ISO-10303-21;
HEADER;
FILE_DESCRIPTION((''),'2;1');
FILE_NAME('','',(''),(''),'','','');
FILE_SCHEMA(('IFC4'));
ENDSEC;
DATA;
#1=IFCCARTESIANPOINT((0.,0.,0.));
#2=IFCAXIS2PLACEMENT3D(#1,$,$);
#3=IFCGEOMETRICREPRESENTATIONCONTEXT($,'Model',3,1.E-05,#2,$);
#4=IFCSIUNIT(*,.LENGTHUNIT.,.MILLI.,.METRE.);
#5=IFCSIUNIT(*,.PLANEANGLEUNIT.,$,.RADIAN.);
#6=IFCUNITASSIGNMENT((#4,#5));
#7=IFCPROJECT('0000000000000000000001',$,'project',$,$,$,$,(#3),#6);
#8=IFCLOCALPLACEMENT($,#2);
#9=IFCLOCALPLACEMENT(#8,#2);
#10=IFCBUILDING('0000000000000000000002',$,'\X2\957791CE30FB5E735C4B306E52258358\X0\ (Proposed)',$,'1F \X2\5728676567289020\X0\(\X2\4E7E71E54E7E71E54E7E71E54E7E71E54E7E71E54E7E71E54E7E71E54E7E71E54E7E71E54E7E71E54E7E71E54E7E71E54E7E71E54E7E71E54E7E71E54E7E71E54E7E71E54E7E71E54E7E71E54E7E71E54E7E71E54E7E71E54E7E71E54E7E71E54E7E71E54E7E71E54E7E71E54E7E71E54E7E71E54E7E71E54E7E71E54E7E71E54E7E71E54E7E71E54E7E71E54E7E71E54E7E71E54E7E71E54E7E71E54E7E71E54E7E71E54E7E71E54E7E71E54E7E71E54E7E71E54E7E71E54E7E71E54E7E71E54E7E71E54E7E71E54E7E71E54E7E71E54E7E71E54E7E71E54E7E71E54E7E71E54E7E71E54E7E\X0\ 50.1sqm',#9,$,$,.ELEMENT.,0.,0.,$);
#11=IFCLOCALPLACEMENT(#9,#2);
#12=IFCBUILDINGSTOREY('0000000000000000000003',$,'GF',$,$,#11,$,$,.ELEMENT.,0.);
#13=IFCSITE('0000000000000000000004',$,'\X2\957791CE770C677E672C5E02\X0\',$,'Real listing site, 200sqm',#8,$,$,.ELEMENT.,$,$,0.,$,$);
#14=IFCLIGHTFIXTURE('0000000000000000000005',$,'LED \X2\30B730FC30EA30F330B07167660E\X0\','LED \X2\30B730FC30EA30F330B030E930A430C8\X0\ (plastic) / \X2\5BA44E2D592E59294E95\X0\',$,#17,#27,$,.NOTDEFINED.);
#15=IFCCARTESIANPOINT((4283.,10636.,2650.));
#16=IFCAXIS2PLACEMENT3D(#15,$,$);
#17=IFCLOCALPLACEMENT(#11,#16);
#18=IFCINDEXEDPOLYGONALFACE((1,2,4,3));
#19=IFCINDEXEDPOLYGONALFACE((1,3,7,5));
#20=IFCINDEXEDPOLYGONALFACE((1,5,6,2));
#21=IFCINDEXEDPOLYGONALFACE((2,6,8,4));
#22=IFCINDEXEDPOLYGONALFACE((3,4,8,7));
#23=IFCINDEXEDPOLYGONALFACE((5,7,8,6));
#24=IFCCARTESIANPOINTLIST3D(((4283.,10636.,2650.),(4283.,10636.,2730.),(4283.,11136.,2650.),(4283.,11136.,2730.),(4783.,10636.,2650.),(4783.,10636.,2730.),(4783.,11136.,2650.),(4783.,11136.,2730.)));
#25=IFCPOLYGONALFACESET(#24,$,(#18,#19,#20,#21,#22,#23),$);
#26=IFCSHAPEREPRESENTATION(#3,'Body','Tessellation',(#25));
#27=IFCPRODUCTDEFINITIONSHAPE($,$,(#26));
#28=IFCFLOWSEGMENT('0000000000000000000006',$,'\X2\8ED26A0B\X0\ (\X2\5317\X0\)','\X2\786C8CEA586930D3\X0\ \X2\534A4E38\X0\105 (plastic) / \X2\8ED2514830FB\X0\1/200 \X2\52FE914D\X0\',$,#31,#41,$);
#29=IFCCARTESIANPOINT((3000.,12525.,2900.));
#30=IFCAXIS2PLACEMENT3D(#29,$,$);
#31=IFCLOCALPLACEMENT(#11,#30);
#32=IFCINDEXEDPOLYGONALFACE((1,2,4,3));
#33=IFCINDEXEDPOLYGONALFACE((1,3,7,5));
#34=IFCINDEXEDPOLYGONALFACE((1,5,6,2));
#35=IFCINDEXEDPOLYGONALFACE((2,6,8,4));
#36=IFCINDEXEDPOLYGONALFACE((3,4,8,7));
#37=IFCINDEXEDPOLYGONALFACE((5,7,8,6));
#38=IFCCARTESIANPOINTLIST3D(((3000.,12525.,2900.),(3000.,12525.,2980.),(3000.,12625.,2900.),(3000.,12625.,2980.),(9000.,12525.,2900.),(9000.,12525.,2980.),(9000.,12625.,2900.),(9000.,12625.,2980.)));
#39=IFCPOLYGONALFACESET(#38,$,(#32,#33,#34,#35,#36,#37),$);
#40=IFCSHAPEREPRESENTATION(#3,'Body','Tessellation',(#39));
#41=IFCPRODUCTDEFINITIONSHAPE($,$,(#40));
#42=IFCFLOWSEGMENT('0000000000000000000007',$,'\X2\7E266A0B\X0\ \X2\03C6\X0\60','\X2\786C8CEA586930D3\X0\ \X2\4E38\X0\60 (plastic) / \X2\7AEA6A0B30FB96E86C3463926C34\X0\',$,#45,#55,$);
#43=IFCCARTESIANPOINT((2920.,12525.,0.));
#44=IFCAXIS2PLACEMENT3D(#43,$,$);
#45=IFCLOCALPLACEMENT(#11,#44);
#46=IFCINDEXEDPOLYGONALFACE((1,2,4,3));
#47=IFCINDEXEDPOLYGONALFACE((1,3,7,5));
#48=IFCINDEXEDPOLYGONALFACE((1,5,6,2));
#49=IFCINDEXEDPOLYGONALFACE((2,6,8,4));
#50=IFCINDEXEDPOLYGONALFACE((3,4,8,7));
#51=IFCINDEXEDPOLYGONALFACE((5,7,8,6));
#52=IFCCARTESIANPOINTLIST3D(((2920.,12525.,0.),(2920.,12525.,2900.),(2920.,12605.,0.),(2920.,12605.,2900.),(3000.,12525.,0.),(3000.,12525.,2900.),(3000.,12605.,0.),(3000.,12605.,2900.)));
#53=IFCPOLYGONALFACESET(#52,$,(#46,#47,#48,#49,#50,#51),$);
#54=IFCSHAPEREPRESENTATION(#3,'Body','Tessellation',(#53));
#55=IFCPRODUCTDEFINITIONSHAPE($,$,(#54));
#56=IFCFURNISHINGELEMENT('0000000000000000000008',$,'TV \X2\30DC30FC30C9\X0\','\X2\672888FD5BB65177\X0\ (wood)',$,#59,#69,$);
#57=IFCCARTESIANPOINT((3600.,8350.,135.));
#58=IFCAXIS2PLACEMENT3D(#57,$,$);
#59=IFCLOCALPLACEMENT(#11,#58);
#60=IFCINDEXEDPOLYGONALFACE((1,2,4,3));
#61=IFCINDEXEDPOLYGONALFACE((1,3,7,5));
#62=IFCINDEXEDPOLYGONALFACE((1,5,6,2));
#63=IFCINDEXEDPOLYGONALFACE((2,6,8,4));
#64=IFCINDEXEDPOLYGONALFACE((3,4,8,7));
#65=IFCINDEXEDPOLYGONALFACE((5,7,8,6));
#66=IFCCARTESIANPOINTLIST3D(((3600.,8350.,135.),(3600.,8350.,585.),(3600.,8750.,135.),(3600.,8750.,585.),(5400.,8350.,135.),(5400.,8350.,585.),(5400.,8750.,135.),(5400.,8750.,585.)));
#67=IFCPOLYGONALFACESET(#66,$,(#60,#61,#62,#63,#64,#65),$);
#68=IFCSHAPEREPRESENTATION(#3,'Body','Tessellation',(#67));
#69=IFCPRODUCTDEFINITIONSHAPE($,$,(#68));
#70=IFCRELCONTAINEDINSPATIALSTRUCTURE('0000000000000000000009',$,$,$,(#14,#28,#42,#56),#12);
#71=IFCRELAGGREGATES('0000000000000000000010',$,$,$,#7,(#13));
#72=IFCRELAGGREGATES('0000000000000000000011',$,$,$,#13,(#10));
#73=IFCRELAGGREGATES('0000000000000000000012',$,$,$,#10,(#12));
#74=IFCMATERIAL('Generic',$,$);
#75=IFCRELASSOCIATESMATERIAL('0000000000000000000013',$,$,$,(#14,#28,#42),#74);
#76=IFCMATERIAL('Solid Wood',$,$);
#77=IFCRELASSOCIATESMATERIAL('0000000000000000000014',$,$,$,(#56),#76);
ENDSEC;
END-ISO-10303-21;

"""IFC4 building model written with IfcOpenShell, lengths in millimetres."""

from ifc_helpers import new_model, si_unit, frame, frame_2d, origin, place, context, project, spatial, rectangle, extrude, material, element, save


model = new_model("IFC4")

# Units and contexts
model_context = context("Model", 3, precision=1e-05, world=origin())
ifc_project = project(units=[si_unit("LENGTHUNIT", "METRE", prefix="MILLI"), si_unit("PLANEANGLEUNIT", "RADIAN")], contexts=[model_context])

# Site, building, storey
site_placement = place(None, origin())
site = spatial("IfcSite", under=ifc_project, at=site_placement, Name="長野県松本市", ObjectType="Real listing site, 200sqm", CompositionType="ELEMENT", RefElevation=0.0)
building_placement = place(site_placement, origin())
building = spatial("IfcBuilding", under=site, at=building_placement, Name="長野・平屋の別荘 (Proposed)", ObjectType="1F 在来木造(乾燥乾燥乾燥乾燥乾燥乾燥乾燥乾燥乾燥乾燥乾燥乾燥乾燥乾燥乾燥乾燥乾燥乾燥乾燥乾燥乾燥乾燥乾燥乾燥乾燥乾燥乾燥乾燥乾燥乾燥乾燥乾燥乾燥乾燥乾燥乾燥乾燥乾燥乾燥乾燥乾燥乾燥乾燥乾燥乾燥乾燥乾燥乾燥乾燥乾燥乾燥乾燥乾燥乾燥乾燥乾燥乾燥乾 50.1sqm", CompositionType="ELEMENT", ElevationOfRefHeight=0.0, ElevationOfTerrain=0.0)
storey_placement = place(building_placement, origin())
storey = spatial("IfcBuildingStorey", under=building, at=storey_placement, Name="GF", CompositionType="ELEMENT", Elevation=0.0)

# Shared definitions
ifc_material_1 = material(Name="Solid Wood")

# Shared definitions
ifc_material_2 = material(Name="Generic")

# Light fixture
light_fixture_placement = place(storey_placement, frame((4283.0, 10636.0, 2650.0)))
element("IfcLightFixture", 1, at=light_fixture_placement, inside=storey, material=ifc_material_2, Name="LED シーリング照明", Description="LED シーリングライト (plastic) / 室中央天井", PredefinedType="NOTDEFINED", context=model_context, shape_type="SweptSolid", body=[
    extrude(rectangle(XDim=500.0, YDim=500.0, at=frame_2d((250.0, 250.0))), frame((4283.0, 10636.0, 2650.0)), (0.0, 0.0, 1.0), 80.0),
])

# Flow segments
flow_segment_1_placement = place(storey_placement, frame((3000.0, 12525.0, 2900.0)))
element("IfcFlowSegment", 2, at=flow_segment_1_placement, inside=storey, material=ifc_material_2, Name="軒樋 (北)", Description="硬質塩ビ 半丸105 (plastic) / 軒先・1/200 勾配", context=model_context, shape_type="SweptSolid", body=[
    extrude(rectangle(XDim=6000.0, YDim=100.0, at=frame_2d((3000.0, 50.0))), frame((3000.0, 12525.0, 2900.0)), (0.0, 0.0, 1.0), 80.0),
])
flow_segment_2_placement = place(storey_placement, frame((2920.0, 12525.0, 0.0)))
element("IfcFlowSegment", 3, at=flow_segment_2_placement, inside=storey, material=ifc_material_2, Name="縦樋 φ60", Description="硬質塩ビ 丸60 (plastic) / 竪樋・雨水排水", context=model_context, shape_type="SweptSolid", body=[
    extrude(rectangle(XDim=80.0, YDim=80.0, at=frame_2d((40.0, 40.0))), frame((2920.0, 12525.0, 0.0)), (0.0, 0.0, 1.0), 2900.0),
])

# Furnishing element
furnishing_placement = place(storey_placement, frame((3600.0, 8350.0, 135.0)))
element("IfcFurnishingElement", 4, at=furnishing_placement, inside=storey, material=ifc_material_1, Name="TV ボード", Description="木製家具 (wood)", context=model_context, shape_type="SweptSolid", body=[
    extrude(rectangle(XDim=1800.0, YDim=400.0, at=frame_2d((900.0, 200.0))), frame((3600.0, 8350.0, 135.0)), (0.0, 0.0, 1.0), 450.0),
])

save(model, "model.ifc")
